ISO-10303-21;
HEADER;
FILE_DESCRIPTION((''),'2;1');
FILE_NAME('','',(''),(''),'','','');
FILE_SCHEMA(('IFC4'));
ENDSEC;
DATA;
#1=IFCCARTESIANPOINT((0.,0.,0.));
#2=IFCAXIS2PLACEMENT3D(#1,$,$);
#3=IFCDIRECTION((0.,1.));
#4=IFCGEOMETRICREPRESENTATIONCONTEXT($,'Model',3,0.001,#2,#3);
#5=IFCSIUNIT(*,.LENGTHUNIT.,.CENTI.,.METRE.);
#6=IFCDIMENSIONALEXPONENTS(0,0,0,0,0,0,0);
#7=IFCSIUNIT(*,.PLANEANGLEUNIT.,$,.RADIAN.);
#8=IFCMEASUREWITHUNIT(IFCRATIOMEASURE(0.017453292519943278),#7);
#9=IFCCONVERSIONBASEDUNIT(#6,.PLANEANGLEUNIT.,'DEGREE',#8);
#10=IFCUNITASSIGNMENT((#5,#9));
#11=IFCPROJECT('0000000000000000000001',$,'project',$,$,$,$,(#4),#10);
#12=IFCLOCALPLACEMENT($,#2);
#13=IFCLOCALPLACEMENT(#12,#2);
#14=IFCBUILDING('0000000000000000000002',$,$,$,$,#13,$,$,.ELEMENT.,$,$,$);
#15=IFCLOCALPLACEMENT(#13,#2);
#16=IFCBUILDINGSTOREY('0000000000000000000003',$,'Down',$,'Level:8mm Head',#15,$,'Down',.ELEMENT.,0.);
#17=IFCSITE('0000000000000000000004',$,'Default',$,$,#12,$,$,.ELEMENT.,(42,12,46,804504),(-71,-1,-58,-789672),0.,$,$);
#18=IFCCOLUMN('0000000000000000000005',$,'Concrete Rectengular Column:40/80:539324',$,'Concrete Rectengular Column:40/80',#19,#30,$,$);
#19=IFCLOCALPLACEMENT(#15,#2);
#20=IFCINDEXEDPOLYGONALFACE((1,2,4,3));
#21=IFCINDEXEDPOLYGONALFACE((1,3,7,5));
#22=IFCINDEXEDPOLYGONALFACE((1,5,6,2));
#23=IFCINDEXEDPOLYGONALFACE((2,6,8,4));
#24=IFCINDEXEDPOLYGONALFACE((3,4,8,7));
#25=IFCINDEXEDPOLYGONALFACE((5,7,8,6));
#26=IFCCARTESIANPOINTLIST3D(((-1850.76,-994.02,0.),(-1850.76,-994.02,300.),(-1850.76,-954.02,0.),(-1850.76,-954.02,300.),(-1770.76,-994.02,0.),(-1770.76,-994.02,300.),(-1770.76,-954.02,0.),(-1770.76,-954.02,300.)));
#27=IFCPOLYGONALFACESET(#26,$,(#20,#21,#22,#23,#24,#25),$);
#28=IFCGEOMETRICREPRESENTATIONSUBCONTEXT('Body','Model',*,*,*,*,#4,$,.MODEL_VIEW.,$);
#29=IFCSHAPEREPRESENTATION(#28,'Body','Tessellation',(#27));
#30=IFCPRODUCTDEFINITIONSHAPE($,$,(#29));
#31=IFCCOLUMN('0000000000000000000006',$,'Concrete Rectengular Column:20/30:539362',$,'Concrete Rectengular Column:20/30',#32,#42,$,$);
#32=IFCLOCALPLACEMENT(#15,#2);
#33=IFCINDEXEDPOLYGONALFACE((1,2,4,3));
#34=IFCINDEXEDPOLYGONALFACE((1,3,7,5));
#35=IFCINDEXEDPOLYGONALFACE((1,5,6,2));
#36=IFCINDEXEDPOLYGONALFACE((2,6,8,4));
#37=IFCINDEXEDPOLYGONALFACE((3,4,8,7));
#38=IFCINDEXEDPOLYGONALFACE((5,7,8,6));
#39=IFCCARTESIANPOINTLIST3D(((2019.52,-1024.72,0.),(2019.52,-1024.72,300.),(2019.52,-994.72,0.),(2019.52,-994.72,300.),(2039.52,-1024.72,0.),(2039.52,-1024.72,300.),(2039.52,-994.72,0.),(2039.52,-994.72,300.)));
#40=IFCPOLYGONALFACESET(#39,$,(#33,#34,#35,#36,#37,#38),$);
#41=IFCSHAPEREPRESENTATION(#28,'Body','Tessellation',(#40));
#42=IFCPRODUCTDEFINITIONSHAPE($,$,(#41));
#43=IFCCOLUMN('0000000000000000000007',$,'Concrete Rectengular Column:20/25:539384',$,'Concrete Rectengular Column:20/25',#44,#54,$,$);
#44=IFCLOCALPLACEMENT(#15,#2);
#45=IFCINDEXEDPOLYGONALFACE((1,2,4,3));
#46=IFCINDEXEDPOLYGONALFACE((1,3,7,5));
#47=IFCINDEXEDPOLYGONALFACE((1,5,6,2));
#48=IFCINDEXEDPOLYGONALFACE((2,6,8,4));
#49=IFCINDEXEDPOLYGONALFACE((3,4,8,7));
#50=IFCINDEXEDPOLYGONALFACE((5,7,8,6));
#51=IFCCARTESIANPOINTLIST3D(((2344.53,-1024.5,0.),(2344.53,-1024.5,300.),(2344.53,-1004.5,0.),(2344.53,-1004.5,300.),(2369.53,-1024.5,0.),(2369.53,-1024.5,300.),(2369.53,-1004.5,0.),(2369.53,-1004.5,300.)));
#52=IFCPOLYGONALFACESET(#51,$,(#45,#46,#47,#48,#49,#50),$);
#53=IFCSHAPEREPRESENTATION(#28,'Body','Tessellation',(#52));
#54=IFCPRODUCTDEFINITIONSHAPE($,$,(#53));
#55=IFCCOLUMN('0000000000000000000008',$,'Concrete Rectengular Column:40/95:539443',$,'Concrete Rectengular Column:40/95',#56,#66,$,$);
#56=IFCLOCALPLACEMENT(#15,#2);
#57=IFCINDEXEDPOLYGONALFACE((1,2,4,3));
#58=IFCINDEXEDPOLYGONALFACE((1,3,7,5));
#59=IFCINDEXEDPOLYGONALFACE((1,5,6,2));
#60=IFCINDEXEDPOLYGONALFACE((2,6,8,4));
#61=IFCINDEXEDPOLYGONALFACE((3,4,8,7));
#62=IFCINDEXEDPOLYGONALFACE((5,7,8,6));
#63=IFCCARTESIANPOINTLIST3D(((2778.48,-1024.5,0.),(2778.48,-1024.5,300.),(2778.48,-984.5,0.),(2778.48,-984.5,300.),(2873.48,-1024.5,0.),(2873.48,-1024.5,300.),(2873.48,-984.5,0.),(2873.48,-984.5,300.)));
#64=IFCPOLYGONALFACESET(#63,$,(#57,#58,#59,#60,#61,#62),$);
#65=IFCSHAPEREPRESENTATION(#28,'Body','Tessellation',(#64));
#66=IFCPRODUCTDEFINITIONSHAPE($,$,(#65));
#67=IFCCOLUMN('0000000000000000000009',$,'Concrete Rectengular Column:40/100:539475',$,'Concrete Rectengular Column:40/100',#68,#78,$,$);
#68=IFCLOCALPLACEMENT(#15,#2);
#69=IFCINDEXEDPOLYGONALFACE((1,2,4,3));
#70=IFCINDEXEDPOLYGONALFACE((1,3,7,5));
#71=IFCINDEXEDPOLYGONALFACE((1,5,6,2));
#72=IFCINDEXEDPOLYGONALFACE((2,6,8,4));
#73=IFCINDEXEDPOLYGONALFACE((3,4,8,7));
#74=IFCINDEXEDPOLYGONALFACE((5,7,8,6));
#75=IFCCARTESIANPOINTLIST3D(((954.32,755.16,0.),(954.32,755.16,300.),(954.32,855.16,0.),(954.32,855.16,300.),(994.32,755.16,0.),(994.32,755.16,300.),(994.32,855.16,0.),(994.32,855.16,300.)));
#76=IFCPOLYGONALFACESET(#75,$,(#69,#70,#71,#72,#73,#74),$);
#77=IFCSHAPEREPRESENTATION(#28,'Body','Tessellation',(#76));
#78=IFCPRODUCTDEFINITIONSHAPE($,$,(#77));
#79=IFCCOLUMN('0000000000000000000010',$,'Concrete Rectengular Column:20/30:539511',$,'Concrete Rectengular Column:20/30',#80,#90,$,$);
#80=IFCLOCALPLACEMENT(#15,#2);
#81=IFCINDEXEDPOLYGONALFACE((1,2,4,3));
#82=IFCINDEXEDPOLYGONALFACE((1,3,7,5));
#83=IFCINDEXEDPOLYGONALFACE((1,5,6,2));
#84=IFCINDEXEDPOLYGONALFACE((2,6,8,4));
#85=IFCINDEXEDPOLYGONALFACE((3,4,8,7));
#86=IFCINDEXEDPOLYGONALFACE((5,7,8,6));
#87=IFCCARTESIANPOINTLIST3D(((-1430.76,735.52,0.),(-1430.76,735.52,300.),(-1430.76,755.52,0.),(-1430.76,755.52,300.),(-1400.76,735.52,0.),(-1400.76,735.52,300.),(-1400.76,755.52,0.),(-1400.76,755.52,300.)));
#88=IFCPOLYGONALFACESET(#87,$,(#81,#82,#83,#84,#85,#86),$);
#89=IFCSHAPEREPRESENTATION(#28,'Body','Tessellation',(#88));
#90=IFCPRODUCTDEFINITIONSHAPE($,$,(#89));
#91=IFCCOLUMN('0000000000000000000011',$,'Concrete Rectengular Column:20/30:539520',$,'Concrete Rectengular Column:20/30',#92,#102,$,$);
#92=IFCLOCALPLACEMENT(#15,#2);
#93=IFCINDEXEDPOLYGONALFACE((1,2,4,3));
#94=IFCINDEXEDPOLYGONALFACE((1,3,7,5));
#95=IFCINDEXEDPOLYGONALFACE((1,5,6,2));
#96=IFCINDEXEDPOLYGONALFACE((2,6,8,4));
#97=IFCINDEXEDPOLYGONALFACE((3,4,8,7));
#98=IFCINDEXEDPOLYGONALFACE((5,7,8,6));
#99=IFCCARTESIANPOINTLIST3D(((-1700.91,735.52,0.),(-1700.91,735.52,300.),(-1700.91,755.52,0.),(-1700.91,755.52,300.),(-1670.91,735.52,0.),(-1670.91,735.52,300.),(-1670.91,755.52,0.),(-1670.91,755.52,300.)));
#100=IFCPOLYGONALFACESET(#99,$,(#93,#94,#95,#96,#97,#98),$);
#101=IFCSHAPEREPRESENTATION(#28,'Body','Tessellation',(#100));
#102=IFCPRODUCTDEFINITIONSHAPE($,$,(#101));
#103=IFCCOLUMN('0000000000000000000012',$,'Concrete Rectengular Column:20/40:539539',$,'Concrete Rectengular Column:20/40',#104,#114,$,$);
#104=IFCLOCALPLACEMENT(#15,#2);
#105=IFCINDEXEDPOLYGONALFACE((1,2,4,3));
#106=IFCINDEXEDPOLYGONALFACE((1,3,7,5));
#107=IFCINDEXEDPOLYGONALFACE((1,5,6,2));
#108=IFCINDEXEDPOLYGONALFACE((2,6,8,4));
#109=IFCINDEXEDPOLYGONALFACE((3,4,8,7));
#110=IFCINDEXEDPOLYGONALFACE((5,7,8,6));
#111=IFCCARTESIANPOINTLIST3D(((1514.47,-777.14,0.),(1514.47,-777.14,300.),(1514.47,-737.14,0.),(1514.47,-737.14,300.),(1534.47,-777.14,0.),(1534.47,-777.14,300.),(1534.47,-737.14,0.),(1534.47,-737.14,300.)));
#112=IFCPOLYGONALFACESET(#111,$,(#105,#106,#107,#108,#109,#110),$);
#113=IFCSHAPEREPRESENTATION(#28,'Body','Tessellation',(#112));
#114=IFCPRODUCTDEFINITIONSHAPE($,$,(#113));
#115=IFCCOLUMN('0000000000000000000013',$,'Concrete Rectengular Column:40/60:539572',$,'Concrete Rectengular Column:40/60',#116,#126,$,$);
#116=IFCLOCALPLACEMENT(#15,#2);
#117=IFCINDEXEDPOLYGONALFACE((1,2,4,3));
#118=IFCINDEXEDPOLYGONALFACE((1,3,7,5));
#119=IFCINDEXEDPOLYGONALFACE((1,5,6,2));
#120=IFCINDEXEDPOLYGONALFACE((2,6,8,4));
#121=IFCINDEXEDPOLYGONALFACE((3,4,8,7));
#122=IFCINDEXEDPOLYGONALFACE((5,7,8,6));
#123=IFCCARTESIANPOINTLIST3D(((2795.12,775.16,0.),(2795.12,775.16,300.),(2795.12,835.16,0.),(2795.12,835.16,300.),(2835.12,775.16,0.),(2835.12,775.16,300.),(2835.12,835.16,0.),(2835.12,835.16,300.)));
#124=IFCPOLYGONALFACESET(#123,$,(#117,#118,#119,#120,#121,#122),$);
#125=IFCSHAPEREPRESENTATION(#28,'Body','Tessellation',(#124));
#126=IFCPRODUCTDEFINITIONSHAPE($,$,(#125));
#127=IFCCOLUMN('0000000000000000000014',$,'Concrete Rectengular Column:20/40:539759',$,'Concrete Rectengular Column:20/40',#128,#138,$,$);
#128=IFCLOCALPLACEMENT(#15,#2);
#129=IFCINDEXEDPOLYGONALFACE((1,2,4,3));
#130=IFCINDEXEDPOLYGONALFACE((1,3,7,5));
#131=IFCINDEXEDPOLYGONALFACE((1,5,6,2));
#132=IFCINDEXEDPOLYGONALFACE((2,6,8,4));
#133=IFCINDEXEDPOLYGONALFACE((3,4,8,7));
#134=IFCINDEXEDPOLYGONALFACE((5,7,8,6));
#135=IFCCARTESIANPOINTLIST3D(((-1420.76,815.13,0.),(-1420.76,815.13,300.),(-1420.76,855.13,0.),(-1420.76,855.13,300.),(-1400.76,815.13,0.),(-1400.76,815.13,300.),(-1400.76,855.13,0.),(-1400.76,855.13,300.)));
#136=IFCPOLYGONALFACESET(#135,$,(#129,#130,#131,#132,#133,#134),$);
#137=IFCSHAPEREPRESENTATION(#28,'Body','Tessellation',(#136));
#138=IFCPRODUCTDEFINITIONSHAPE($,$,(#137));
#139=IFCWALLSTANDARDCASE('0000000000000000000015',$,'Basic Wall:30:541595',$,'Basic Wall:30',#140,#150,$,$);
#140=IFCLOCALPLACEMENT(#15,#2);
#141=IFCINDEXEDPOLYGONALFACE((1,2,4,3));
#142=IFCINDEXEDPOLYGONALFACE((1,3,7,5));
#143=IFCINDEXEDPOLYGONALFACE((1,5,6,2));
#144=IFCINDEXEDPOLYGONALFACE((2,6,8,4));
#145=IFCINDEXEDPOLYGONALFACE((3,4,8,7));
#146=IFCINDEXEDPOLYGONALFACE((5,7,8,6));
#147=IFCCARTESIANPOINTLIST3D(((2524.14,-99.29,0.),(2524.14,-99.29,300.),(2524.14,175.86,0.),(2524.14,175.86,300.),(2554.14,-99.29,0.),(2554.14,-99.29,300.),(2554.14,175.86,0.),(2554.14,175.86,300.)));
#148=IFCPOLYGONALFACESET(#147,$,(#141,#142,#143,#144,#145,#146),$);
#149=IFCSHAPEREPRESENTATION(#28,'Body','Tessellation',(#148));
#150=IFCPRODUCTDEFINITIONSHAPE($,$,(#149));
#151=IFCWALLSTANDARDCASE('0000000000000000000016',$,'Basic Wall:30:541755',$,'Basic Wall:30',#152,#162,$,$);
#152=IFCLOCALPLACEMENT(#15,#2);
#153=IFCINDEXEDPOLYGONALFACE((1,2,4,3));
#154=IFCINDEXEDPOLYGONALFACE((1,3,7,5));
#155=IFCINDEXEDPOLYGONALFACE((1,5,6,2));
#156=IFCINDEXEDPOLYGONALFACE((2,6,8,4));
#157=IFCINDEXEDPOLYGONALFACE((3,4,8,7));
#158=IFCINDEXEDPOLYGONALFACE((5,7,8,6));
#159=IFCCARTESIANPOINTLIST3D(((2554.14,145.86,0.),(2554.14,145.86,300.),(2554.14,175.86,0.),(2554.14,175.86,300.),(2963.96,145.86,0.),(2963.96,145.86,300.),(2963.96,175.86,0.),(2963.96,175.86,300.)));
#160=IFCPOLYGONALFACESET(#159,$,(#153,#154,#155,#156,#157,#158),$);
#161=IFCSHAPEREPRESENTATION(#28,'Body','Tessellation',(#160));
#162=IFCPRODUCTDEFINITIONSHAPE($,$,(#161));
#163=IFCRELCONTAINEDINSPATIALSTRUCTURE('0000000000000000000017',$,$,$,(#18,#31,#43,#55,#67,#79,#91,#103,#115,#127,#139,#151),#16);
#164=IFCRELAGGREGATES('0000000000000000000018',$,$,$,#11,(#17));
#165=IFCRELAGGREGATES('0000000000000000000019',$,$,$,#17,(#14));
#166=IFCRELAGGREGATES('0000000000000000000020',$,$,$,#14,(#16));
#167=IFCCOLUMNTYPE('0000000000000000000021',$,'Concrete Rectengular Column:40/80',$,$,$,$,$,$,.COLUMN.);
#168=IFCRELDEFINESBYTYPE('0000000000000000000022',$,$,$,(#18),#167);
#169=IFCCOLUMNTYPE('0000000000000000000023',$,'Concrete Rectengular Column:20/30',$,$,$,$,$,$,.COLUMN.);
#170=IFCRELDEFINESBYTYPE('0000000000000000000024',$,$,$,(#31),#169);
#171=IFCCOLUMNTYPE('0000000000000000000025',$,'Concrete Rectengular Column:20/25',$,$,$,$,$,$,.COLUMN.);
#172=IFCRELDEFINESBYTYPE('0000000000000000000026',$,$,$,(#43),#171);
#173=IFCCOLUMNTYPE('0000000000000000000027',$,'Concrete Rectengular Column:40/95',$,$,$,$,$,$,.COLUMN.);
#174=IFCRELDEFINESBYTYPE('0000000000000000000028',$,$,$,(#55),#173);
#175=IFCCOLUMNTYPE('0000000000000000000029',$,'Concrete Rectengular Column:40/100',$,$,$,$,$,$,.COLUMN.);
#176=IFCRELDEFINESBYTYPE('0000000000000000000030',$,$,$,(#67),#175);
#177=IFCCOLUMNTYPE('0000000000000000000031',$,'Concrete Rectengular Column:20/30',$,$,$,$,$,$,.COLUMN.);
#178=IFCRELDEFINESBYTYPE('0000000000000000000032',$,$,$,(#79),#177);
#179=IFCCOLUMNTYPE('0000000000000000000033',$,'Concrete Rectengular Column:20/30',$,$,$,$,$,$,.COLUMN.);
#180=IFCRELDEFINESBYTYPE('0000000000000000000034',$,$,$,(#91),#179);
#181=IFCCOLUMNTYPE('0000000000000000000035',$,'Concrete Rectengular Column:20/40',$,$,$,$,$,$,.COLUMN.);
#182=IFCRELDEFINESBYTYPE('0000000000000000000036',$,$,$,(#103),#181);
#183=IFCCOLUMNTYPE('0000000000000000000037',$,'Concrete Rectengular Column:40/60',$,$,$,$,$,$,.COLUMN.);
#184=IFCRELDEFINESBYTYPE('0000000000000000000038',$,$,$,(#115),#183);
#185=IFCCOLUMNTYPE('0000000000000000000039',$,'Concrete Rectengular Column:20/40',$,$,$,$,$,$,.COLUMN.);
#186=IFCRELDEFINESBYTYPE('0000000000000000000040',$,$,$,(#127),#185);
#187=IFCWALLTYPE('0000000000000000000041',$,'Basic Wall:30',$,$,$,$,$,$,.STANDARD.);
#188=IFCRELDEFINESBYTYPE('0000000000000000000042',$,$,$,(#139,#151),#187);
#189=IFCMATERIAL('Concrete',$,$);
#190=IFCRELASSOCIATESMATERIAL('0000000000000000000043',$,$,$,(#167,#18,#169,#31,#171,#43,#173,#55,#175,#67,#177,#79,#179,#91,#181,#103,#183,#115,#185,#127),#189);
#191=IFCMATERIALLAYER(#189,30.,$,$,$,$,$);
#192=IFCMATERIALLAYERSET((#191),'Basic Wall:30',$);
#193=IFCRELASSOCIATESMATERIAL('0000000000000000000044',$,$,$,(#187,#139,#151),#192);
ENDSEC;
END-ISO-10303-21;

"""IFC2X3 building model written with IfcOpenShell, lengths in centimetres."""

from ifc_helpers import new_model, entity, si_unit, converted_unit, direction, frame, frame_2d, origin, origin_2d_with_axis, place, context, subcontext, project, spatial, rectangle, extrude, source, transform, mapped, material, layer, layer_set, layer_usage, type_object, type_shapes, element, save


model = new_model("IFC2X3")

# Units and contexts
model_context = context("Model", 3, precision=0.001, world=origin(), true_north=direction((0.0, 1.0)))
body_context = subcontext(model_context, "Body", "Model", "MODEL_VIEW")
ifc_project = project(units=[si_unit("LENGTHUNIT", "METRE", prefix="CENTI"), converted_unit("PLANEANGLEUNIT", "DEGREE", entity("IfcRatioMeasure", 0.017453292519943278), si_unit("PLANEANGLEUNIT", "RADIAN"), dimensions=[0, 0, 0, 0, 0, 0, 0])], contexts=[model_context])

# Site, building, storey
site_placement = place(None, origin())
site = spatial("IfcSite", under=ifc_project, at=site_placement, Name="Default", CompositionType="ELEMENT", RefLatitude=(42, 12, 46, 804504), RefLongitude=(-71, -1, -58, -789672), RefElevation=0.0)
building_placement = place(site_placement, origin())
building = spatial("IfcBuilding", under=site, at=building_placement, CompositionType="ELEMENT")
storey_placement = place(building_placement, origin())
storey = spatial("IfcBuildingStorey", under=building, at=storey_placement, Name="Down", ObjectType="Level:8mm Head", LongName="Down", CompositionType="ELEMENT", Elevation=0.0)

# Columns
ifc_material = material(Name="Concrete")
column_type_1 = type_object("IfcColumnType", Name="Concrete Rectengular Column:40/80", PredefinedType="COLUMN", material=ifc_material)
shared_shape_1 = source(origin(), body_context, "Body", "SweptSolid", [
    extrude(rectangle(XDim=40.0, YDim=80.0, at=frame_2d((0.0, 0.0), x_axis=(1.0, 0.0))), frame((-1810.76, -974.02, 0.0), z_axis=(0.0, 0.0, 1.0), x_axis=(0.0, -1.0, 0.0)), (0.0, 0.0, 1.0), 300.0),
])
type_shapes(column_type_1, [shared_shape_1])
column_1_placement = place(storey_placement, origin())
element("IfcColumn", 1, at=column_1_placement, inside=storey, type_object=column_type_1, material=ifc_material, Name="Concrete Rectengular Column:40/80:539324", ObjectType="Concrete Rectengular Column:40/80", context=body_context, shape_type="MappedRepresentation", body=[
    mapped(shared_shape_1, transform((0.0, 0.0, 0.0), scale=1.0)),
])
column_type_2 = type_object("IfcColumnType", Name="Concrete Rectengular Column:20/30", PredefinedType="COLUMN", material=ifc_material)
shared_shape_2 = source(origin(), body_context, "Body", "SweptSolid", [
    extrude(rectangle(XDim=30.0, YDim=20.0, at=origin_2d_with_axis()), frame((2029.52, -1009.72, 0.0), z_axis=(0.0, 0.0, 1.0), x_axis=(0.0, -1.0, 0.0)), (0.0, 0.0, 1.0), 300.0),
])
type_shapes(column_type_2, [shared_shape_2])
column_2_placement = place(storey_placement, origin())
element("IfcColumn", 2, at=column_2_placement, inside=storey, type_object=column_type_2, material=ifc_material, Name="Concrete Rectengular Column:20/30:539362", ObjectType="Concrete Rectengular Column:20/30", context=body_context, shape_type="MappedRepresentation", body=[
    mapped(shared_shape_2, transform((0.0, 0.0, 0.0), scale=1.0)),
])
column_type_3 = type_object("IfcColumnType", Name="Concrete Rectengular Column:20/25", PredefinedType="COLUMN", material=ifc_material)
shared_shape_3 = source(origin(), body_context, "Body", "SweptSolid", [
    extrude(rectangle(XDim=20.0, YDim=25.0, at=frame_2d((0.0, 0.0), x_axis=(1.0, 0.0))), frame((2357.03, -1014.5, 0.0), z_axis=(0.0, 0.0, 1.0), x_axis=(0.0, -1.0, 0.0)), (0.0, 0.0, 1.0), 300.0),
])
type_shapes(column_type_3, [shared_shape_3])
column_3_placement = place(storey_placement, origin())
element("IfcColumn", 3, at=column_3_placement, inside=storey, type_object=column_type_3, material=ifc_material, Name="Concrete Rectengular Column:20/25:539384", ObjectType="Concrete Rectengular Column:20/25", context=body_context, shape_type="MappedRepresentation", body=[
    mapped(shared_shape_3, transform((0.0, 0.0, 0.0), scale=1.0)),
])
column_type_4 = type_object("IfcColumnType", Name="Concrete Rectengular Column:40/95", PredefinedType="COLUMN", material=ifc_material)
shared_shape_4 = source(origin(), body_context, "Body", "SweptSolid", [
    extrude(rectangle(XDim=40.0, YDim=95.0, at=frame_2d((0.0, 0.0), x_axis=(1.0, 0.0))), frame((2825.98, -1004.5, 0.0), z_axis=(0.0, 0.0, 1.0), x_axis=(0.0, -1.0, 0.0)), (0.0, 0.0, 1.0), 300.0),
])
type_shapes(column_type_4, [shared_shape_4])
column_4_placement = place(storey_placement, origin())
element("IfcColumn", 4, at=column_4_placement, inside=storey, type_object=column_type_4, material=ifc_material, Name="Concrete Rectengular Column:40/95:539443", ObjectType="Concrete Rectengular Column:40/95", context=body_context, shape_type="MappedRepresentation", body=[
    mapped(shared_shape_4, transform((0.0, 0.0, 0.0), scale=1.0)),
])
column_type_5 = type_object("IfcColumnType", Name="Concrete Rectengular Column:40/100", PredefinedType="COLUMN", material=ifc_material)
shared_shape_5 = source(origin(), body_context, "Body", "SweptSolid", [
    extrude(rectangle(XDim=100.0, YDim=40.0, at=origin_2d_with_axis()), frame((974.32, 805.16, 0.0), z_axis=(0.0, 0.0, 1.0), x_axis=(0.0, -1.0, 0.0)), (0.0, 0.0, 1.0), 300.0),
])
type_shapes(column_type_5, [shared_shape_5])
column_5_placement = place(storey_placement, origin())
element("IfcColumn", 5, at=column_5_placement, inside=storey, type_object=column_type_5, material=ifc_material, Name="Concrete Rectengular Column:40/100:539475", ObjectType="Concrete Rectengular Column:40/100", context=body_context, shape_type="MappedRepresentation", body=[
    mapped(shared_shape_5, transform((0.0, 0.0, 0.0), scale=1.0)),
])
column_type_6 = type_object("IfcColumnType", Name="Concrete Rectengular Column:20/30", PredefinedType="COLUMN", material=ifc_material)
shared_shape_6 = source(origin(), body_context, "Body", "SweptSolid", [
    extrude(rectangle(XDim=20.0, YDim=30.0, at=origin_2d_with_axis()), frame((-1415.76, 745.52, 0.0), z_axis=(0.0, 0.0, 1.0), x_axis=(0.0, -1.0, 0.0)), (0.0, 0.0, 1.0), 300.0),
])
type_shapes(column_type_6, [shared_shape_6])
column_6_placement = place(storey_placement, origin())
element("IfcColumn", 6, at=column_6_placement, inside=storey, type_object=column_type_6, material=ifc_material, Name="Concrete Rectengular Column:20/30:539511", ObjectType="Concrete Rectengular Column:20/30", context=body_context, shape_type="MappedRepresentation", body=[
    mapped(shared_shape_6, transform((0.0, 0.0, 0.0), scale=1.0)),
])
column_type_7 = type_object("IfcColumnType", Name="Concrete Rectengular Column:20/30", PredefinedType="COLUMN", material=ifc_material)
shared_shape_7 = source(origin(), body_context, "Body", "SweptSolid", [
    extrude(rectangle(XDim=20.0, YDim=30.0, at=origin_2d_with_axis()), frame((-1685.91, 745.52, 0.0), z_axis=(0.0, 0.0, 1.0), x_axis=(0.0, -1.0, 0.0)), (0.0, 0.0, 1.0), 300.0),
])
type_shapes(column_type_7, [shared_shape_7])
column_7_placement = place(storey_placement, origin())
element("IfcColumn", 7, at=column_7_placement, inside=storey, type_object=column_type_7, material=ifc_material, Name="Concrete Rectengular Column:20/30:539520", ObjectType="Concrete Rectengular Column:20/30", context=body_context, shape_type="MappedRepresentation", body=[
    mapped(shared_shape_7, transform((0.0, 0.0, 0.0), scale=1.0)),
])
column_type_8 = type_object("IfcColumnType", Name="Concrete Rectengular Column:20/40", PredefinedType="COLUMN", material=ifc_material)
shared_shape_8 = source(origin(), body_context, "Body", "SweptSolid", [
    extrude(rectangle(XDim=40.0, YDim=20.0, at=frame_2d((0.0, 0.0), x_axis=(1.0, 0.0))), frame((1524.47, -757.14, 0.0), z_axis=(0.0, 0.0, 1.0), x_axis=(0.0, -1.0, 0.0)), (0.0, 0.0, 1.0), 300.0),
])
type_shapes(column_type_8, [shared_shape_8])
column_8_placement = place(storey_placement, origin())
element("IfcColumn", 8, at=column_8_placement, inside=storey, type_object=column_type_8, material=ifc_material, Name="Concrete Rectengular Column:20/40:539539", ObjectType="Concrete Rectengular Column:20/40", context=body_context, shape_type="MappedRepresentation", body=[
    mapped(shared_shape_8, transform((0.0, 0.0, 0.0), scale=1.0)),
])
column_type_9 = type_object("IfcColumnType", Name="Concrete Rectengular Column:40/60", PredefinedType="COLUMN", material=ifc_material)
shared_shape_9 = source(origin(), body_context, "Body", "SweptSolid", [
    extrude(rectangle(XDim=60.0, YDim=40.0, at=frame_2d((0.0, 0.0), x_axis=(1.0, 0.0))), frame((2815.12, 805.16, 0.0), z_axis=(0.0, 0.0, 1.0), x_axis=(0.0, -1.0, 0.0)), (0.0, 0.0, 1.0), 300.0),
])
type_shapes(column_type_9, [shared_shape_9])
column_9_placement = place(storey_placement, origin())
element("IfcColumn", 9, at=column_9_placement, inside=storey, type_object=column_type_9, material=ifc_material, Name="Concrete Rectengular Column:40/60:539572", ObjectType="Concrete Rectengular Column:40/60", context=body_context, shape_type="MappedRepresentation", body=[
    mapped(shared_shape_9, transform((0.0, 0.0, 0.0), scale=1.0)),
])
column_type_10 = type_object("IfcColumnType", Name="Concrete Rectengular Column:20/40", PredefinedType="COLUMN", material=ifc_material)
shared_shape_10 = source(origin(), body_context, "Body", "SweptSolid", [
    extrude(rectangle(XDim=40.0, YDim=20.0, at=frame_2d((0.0, 0.0), x_axis=(1.0, 0.0))), frame((-1410.76, 835.13, 0.0), z_axis=(0.0, 0.0, 1.0), x_axis=(0.0, -1.0, 0.0)), (0.0, 0.0, 1.0), 300.0),
])
type_shapes(column_type_10, [shared_shape_10])
column_10_placement = place(storey_placement, origin())
element("IfcColumn", 10, at=column_10_placement, inside=storey, type_object=column_type_10, material=ifc_material, Name="Concrete Rectengular Column:20/40:539759", ObjectType="Concrete Rectengular Column:20/40", context=body_context, shape_type="MappedRepresentation", body=[
    mapped(shared_shape_10, transform((0.0, 0.0, 0.0), scale=1.0)),
])

# Walls
ifc_layer_1 = layer(ifc_material, 30.0)
ifc_layer_set_1 = layer_set([ifc_layer_1], Name="Basic Wall:30")
ifc_layer_usage_1 = layer_usage(ifc_layer_set_1, "AXIS2", "NEGATIVE", 15.0)
wall_type_1 = type_object("IfcWallType", Name="Basic Wall:30", PredefinedType="STANDARD", material=ifc_layer_set_1)
wall_1_placement = place(storey_placement, frame((2539.14, -99.29, 0.0), z_axis=(0.0, 0.0, 1.0), x_axis=(0.0, 1.0, 0.0)))
element("IfcWallStandardCase", 11, at=wall_1_placement, inside=storey, type_object=wall_type_1, material=ifc_layer_usage_1, Name="Basic Wall:30:541595", ObjectType="Basic Wall:30", context=body_context, shape_type="SweptSolid", body=[
    extrude(rectangle(XDim=275.15, YDim=30.0, at=frame_2d((137.58, 0.0), x_axis=(-1.0, 0.0))), origin(), (0.0, 0.0, 1.0), 300.0),
])
ifc_layer_usage_2 = layer_usage(ifc_layer_set_1, "AXIS2", "NEGATIVE", 15.0)
wall_2_placement = place(storey_placement, frame((2554.14, 160.86, 0.0)))
element("IfcWallStandardCase", 12, at=wall_2_placement, inside=storey, type_object=wall_type_1, material=ifc_layer_usage_2, Name="Basic Wall:30:541755", ObjectType="Basic Wall:30", context=body_context, shape_type="SweptSolid", body=[
    extrude(rectangle(XDim=409.82, YDim=30.0, at=frame_2d((204.91, 0.0), x_axis=(-1.0, 0.0))), origin(), (0.0, 0.0, 1.0), 300.0),
])

save(model, "model.ifc")
